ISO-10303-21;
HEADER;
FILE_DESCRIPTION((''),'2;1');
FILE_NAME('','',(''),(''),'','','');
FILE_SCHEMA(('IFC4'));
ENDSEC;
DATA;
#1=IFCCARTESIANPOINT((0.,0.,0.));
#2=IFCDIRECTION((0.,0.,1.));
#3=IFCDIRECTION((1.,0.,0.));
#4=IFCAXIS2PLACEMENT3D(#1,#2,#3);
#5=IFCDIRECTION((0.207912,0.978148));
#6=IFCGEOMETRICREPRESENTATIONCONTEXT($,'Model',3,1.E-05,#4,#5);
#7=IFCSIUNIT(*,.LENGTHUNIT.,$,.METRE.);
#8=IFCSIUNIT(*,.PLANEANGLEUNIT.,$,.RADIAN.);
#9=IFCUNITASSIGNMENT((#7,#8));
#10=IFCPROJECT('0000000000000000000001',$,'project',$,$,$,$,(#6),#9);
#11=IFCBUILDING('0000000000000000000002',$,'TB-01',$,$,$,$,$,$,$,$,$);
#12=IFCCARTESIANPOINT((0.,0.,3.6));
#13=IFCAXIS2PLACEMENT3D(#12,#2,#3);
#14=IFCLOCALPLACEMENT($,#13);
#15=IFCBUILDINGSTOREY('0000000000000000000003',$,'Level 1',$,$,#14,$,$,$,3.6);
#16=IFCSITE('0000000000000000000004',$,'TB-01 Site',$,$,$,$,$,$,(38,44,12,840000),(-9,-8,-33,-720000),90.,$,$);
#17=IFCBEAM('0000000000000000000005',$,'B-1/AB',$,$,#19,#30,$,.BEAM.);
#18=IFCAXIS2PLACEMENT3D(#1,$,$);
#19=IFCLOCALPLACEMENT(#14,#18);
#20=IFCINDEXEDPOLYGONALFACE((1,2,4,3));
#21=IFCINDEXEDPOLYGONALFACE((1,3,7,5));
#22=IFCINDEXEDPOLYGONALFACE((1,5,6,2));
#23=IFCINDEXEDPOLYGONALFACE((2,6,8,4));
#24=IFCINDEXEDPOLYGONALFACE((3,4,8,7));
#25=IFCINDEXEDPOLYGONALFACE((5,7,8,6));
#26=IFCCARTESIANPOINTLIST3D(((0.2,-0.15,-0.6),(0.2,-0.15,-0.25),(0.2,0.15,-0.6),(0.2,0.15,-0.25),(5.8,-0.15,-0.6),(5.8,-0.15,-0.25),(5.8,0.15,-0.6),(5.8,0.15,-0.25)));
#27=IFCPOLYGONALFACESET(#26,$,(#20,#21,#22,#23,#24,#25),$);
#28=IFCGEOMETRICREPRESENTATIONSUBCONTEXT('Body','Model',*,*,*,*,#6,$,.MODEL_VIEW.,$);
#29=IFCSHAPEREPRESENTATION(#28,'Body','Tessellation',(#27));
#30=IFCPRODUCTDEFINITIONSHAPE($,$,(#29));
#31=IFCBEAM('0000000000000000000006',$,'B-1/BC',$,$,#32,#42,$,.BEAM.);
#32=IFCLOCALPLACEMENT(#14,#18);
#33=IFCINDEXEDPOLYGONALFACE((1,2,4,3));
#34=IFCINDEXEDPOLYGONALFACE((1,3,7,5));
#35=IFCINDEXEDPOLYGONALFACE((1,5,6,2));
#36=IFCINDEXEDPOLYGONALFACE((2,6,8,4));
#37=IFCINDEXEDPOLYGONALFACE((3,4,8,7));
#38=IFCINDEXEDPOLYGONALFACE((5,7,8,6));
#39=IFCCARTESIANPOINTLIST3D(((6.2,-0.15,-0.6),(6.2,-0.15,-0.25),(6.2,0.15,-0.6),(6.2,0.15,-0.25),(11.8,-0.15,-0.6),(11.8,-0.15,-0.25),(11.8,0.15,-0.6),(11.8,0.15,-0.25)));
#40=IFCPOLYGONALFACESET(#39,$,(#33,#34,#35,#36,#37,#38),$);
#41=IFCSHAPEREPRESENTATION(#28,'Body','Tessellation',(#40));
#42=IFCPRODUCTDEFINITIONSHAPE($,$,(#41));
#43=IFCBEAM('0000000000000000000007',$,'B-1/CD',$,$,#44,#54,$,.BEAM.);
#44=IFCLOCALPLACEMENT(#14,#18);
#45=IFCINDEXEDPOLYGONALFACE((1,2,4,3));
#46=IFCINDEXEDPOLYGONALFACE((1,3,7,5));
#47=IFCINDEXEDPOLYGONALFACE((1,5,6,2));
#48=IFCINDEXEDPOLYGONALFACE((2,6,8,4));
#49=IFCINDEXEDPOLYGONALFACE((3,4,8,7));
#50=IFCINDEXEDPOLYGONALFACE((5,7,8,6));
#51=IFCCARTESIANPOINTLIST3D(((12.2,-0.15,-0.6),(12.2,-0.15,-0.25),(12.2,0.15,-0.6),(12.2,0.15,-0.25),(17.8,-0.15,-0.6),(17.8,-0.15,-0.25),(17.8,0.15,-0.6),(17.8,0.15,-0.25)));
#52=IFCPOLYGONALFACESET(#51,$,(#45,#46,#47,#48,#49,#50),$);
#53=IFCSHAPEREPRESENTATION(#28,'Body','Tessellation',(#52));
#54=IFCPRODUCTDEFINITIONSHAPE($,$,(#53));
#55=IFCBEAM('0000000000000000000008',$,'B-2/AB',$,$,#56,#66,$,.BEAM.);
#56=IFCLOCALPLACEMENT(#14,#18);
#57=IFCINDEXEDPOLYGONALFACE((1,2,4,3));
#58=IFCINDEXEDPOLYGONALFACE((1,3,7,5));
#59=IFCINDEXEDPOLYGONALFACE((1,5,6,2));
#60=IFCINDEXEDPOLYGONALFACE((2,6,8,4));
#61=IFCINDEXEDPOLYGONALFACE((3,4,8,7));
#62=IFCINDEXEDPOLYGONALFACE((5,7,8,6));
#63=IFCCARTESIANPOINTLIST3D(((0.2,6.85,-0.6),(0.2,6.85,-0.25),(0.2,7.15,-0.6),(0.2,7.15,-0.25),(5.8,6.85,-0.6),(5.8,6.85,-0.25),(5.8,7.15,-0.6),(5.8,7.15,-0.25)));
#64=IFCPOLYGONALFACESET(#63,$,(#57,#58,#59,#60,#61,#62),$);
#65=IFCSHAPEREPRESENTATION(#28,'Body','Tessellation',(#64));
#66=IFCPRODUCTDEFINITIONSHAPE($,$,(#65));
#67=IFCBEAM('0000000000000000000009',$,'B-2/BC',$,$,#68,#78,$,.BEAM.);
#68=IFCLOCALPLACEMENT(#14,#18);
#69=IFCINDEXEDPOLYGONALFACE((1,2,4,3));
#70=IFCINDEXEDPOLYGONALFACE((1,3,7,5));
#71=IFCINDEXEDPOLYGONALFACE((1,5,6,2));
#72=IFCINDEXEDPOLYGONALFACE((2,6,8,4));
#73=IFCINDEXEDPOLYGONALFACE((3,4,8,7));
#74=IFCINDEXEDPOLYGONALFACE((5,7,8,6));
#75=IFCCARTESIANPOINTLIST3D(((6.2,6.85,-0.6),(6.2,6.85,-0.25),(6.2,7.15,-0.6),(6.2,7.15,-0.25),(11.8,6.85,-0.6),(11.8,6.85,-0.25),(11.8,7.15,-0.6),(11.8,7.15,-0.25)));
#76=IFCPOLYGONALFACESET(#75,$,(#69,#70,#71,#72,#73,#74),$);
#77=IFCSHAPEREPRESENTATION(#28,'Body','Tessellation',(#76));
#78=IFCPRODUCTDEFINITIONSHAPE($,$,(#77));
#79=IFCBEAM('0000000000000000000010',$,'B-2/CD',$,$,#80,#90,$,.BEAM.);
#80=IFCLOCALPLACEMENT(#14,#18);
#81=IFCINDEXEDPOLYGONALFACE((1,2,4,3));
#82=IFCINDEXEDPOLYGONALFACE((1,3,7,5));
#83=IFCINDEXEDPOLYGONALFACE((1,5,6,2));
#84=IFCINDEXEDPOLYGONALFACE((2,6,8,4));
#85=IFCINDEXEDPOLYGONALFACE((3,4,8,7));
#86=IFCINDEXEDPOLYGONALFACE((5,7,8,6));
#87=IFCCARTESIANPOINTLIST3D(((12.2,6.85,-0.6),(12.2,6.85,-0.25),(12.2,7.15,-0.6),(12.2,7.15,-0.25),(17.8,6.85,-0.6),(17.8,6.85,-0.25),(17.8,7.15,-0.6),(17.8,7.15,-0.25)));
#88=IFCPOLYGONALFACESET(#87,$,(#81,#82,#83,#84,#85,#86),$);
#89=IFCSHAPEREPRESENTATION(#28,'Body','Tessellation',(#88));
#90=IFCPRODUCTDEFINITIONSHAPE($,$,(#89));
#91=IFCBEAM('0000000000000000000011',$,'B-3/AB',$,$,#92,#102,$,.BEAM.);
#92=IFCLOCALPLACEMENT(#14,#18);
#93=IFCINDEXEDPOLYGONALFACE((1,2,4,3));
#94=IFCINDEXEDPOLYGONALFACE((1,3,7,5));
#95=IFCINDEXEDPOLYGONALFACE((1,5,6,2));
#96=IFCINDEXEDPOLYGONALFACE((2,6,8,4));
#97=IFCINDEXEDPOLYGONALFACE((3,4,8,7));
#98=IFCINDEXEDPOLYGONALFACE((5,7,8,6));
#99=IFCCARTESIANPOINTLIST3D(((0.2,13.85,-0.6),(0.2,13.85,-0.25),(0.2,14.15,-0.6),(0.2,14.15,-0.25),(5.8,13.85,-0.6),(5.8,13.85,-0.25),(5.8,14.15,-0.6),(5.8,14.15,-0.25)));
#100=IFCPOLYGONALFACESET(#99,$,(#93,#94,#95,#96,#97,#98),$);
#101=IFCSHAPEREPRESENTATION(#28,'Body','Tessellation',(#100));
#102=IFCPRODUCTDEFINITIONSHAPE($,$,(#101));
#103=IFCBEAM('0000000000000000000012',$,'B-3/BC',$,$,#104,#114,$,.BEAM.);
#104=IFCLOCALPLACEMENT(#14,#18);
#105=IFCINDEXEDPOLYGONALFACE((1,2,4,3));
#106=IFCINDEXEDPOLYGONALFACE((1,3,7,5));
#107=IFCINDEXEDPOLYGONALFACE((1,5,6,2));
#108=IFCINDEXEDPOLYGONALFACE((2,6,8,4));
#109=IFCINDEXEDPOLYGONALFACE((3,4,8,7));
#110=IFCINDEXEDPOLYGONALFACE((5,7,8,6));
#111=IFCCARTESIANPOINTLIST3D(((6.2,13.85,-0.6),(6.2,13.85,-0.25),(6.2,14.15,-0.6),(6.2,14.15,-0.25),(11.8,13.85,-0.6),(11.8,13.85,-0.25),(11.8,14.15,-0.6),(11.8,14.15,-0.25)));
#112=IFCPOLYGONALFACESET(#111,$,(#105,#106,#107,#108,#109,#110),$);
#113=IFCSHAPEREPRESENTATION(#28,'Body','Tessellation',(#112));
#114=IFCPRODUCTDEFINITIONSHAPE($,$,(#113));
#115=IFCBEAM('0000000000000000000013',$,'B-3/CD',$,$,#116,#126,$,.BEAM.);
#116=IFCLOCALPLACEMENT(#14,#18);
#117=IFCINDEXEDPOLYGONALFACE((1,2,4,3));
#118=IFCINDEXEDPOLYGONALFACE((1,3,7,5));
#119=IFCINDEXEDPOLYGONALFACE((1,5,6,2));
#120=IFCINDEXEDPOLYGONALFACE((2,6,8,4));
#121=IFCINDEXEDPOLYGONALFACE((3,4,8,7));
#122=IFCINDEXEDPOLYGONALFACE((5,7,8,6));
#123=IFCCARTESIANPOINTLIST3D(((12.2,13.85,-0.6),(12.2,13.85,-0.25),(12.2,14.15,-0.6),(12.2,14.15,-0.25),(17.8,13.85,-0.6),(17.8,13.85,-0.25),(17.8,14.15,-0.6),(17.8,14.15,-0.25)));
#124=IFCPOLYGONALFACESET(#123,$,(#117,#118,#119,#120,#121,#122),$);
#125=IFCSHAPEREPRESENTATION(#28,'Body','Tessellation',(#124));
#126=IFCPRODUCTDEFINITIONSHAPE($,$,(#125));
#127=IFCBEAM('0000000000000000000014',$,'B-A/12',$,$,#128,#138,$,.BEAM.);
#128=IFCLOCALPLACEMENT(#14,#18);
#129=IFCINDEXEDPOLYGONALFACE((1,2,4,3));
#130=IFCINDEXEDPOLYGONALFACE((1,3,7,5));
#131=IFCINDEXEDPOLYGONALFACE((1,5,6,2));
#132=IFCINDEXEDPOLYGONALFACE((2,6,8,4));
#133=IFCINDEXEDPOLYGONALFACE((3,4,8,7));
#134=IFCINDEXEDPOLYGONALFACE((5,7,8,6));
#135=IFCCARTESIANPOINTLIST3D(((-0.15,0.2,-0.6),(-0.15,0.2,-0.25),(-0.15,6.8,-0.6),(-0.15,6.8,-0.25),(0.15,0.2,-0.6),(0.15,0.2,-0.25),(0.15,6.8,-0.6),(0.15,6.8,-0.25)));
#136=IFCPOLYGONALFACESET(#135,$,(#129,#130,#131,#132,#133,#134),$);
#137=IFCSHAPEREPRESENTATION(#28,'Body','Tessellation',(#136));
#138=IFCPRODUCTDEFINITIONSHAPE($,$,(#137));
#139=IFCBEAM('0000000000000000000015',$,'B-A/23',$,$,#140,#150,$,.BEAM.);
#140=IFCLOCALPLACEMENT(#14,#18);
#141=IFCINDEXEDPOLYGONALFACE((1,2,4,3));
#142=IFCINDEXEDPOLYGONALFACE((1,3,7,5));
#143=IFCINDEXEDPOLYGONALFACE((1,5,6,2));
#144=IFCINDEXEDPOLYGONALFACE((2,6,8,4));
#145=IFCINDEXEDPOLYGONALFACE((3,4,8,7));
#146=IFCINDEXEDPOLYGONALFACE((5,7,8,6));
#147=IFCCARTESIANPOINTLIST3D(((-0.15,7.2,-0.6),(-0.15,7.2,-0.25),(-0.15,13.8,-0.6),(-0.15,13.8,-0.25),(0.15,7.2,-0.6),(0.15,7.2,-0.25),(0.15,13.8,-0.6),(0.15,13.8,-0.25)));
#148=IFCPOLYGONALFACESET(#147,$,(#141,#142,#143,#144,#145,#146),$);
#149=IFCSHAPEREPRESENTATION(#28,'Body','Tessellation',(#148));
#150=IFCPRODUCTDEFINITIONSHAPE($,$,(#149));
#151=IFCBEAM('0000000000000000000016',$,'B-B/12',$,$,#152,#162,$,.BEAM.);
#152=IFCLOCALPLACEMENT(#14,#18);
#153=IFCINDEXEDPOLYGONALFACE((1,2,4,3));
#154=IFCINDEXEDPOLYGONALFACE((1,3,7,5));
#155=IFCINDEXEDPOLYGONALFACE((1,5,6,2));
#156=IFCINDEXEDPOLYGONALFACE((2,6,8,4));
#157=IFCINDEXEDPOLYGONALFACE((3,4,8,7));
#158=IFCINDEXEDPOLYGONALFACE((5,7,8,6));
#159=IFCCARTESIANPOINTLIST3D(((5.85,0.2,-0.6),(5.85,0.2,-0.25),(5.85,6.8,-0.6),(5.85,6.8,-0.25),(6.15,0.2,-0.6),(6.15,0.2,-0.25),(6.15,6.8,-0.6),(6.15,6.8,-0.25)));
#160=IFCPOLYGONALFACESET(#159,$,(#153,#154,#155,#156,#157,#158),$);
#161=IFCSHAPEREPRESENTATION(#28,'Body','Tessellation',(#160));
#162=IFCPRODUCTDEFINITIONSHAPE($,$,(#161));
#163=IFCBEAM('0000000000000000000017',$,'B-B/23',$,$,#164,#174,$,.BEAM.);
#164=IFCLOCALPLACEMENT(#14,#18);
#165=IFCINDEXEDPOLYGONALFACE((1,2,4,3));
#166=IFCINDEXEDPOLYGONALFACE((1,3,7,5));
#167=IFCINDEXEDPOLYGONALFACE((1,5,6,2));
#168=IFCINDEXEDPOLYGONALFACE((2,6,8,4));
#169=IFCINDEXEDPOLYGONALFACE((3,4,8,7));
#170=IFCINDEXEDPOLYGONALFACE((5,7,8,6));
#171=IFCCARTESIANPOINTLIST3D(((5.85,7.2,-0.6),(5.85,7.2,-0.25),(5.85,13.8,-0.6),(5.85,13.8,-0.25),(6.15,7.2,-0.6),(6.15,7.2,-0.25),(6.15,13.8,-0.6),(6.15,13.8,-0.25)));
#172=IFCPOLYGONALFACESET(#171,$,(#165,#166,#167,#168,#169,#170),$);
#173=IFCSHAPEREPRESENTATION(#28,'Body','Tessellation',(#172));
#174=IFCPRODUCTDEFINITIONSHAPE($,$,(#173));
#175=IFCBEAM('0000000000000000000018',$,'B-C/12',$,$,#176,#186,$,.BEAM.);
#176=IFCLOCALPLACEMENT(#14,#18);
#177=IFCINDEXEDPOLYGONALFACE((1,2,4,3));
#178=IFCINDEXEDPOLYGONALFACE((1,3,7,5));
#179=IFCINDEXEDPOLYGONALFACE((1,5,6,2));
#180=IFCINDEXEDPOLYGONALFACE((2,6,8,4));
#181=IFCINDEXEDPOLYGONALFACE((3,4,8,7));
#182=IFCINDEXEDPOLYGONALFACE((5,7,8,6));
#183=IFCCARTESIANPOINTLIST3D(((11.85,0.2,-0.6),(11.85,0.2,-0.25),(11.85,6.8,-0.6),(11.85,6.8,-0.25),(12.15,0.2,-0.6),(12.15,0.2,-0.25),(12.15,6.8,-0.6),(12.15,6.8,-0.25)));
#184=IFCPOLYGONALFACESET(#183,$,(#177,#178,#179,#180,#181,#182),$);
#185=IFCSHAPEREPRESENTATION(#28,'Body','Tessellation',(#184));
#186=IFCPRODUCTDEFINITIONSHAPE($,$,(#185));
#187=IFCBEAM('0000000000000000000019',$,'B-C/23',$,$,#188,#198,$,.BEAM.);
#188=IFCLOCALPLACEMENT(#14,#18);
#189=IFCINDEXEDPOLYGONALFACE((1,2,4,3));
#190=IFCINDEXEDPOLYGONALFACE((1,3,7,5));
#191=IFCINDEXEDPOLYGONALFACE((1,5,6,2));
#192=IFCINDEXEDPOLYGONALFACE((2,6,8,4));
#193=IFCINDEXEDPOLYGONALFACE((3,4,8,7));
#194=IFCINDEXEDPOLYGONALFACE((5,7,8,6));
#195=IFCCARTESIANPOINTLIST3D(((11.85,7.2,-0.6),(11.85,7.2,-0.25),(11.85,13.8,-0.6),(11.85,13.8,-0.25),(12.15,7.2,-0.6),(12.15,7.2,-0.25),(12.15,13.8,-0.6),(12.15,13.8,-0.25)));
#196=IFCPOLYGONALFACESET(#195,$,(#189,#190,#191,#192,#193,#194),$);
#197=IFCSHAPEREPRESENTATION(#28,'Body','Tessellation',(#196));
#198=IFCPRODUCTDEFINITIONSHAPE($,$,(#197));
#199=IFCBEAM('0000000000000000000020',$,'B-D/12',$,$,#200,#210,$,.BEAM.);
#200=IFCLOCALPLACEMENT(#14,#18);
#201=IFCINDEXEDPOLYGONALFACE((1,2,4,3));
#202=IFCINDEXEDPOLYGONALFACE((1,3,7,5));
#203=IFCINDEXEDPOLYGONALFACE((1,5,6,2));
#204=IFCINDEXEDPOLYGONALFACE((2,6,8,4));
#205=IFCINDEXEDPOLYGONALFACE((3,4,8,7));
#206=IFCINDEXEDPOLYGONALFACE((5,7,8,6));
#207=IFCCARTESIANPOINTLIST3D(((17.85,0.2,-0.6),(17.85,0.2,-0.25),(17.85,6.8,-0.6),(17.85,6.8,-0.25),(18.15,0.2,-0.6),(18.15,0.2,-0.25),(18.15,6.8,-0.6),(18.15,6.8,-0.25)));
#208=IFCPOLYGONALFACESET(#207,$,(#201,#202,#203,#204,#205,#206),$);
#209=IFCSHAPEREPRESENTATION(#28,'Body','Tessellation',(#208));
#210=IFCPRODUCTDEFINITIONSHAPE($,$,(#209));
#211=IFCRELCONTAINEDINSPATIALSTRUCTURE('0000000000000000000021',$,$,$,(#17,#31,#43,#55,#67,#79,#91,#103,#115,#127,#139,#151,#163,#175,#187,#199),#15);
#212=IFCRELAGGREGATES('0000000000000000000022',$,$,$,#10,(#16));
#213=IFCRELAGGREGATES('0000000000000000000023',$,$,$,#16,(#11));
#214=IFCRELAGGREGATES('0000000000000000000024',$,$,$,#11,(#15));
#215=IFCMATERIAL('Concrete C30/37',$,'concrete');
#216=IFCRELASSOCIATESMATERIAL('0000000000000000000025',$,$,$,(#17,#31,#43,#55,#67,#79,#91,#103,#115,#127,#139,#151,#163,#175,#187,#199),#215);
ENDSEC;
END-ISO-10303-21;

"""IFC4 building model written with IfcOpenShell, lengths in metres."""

from ifc_helpers import new_model, si_unit, direction, frame, origin_with_axes, place, context, subcontext, project, spatial, rectangle, extrude, material, element, save


model = new_model("IFC4")

# Units and contexts
model_context = context("Model", 3, precision=1e-05, world=origin_with_axes(), true_north=direction((0.207912, 0.978148)))
body_context = subcontext(model_context, "Body", "Model", "MODEL_VIEW")
ifc_project = project(units=[si_unit("LENGTHUNIT", "METRE"), si_unit("PLANEANGLEUNIT", "RADIAN")], contexts=[model_context])

# Site, building, storey
site = spatial("IfcSite", under=ifc_project, Name="TB-01 Site", RefLatitude=(38, 44, 12, 840000), RefLongitude=(-9, -8, -33, -720000), RefElevation=90.0)
building = spatial("IfcBuilding", under=site, Name="TB-01")
storey_placement = place(None, frame((0.0, 0.0, 3.6), z_axis=(0.0, 0.0, 1.0), x_axis=(1.0, 0.0, 0.0)))
storey = spatial("IfcBuildingStorey", under=building, at=storey_placement, Name="Level 1", Elevation=3.6)

# Beams
ifc_material = material(Name="Concrete C30/37", Category="concrete")
beam_1_placement = place(storey_placement, frame((0.2, 0.0, -0.425), z_axis=(1.0, 0.0, 0.0), x_axis=(0.0, 1.0, 0.0)))
element("IfcBeam", 1, at=beam_1_placement, inside=storey, material=ifc_material, Name="B-1/AB", PredefinedType="BEAM", context=body_context, shape_type="SweptSolid", body=[
    extrude(rectangle(XDim=0.3, YDim=0.35), origin_with_axes(), (0.0, 0.0, 1.0), 5.6),
])
beam_2_placement = place(storey_placement, frame((6.2, 0.0, -0.425), z_axis=(1.0, 0.0, 0.0), x_axis=(0.0, 1.0, 0.0)))
element("IfcBeam", 2, at=beam_2_placement, inside=storey, material=ifc_material, Name="B-1/BC", PredefinedType="BEAM", context=body_context, shape_type="SweptSolid", body=[
    extrude(rectangle(XDim=0.3, YDim=0.35), origin_with_axes(), (0.0, 0.0, 1.0), 5.6),
])
beam_3_placement = place(storey_placement, frame((12.2, 0.0, -0.425), z_axis=(1.0, 0.0, 0.0), x_axis=(0.0, 1.0, 0.0)))
element("IfcBeam", 3, at=beam_3_placement, inside=storey, material=ifc_material, Name="B-1/CD", PredefinedType="BEAM", context=body_context, shape_type="SweptSolid", body=[
    extrude(rectangle(XDim=0.3, YDim=0.35), origin_with_axes(), (0.0, 0.0, 1.0), 5.6),
])
beam_4_placement = place(storey_placement, frame((0.2, 7.0, -0.425), z_axis=(1.0, 0.0, 0.0), x_axis=(0.0, 1.0, 0.0)))
element("IfcBeam", 4, at=beam_4_placement, inside=storey, material=ifc_material, Name="B-2/AB", PredefinedType="BEAM", context=body_context, shape_type="SweptSolid", body=[
    extrude(rectangle(XDim=0.3, YDim=0.35), origin_with_axes(), (0.0, 0.0, 1.0), 5.6),
])
beam_5_placement = place(storey_placement, frame((6.2, 7.0, -0.425), z_axis=(1.0, 0.0, 0.0), x_axis=(0.0, 1.0, 0.0)))
element("IfcBeam", 5, at=beam_5_placement, inside=storey, material=ifc_material, Name="B-2/BC", PredefinedType="BEAM", context=body_context, shape_type="SweptSolid", body=[
    extrude(rectangle(XDim=0.3, YDim=0.35), origin_with_axes(), (0.0, 0.0, 1.0), 5.6),
])
beam_6_placement = place(storey_placement, frame((12.2, 7.0, -0.425), z_axis=(1.0, 0.0, 0.0), x_axis=(0.0, 1.0, 0.0)))
element("IfcBeam", 6, at=beam_6_placement, inside=storey, material=ifc_material, Name="B-2/CD", PredefinedType="BEAM", context=body_context, shape_type="SweptSolid", body=[
    extrude(rectangle(XDim=0.3, YDim=0.35), origin_with_axes(), (0.0, 0.0, 1.0), 5.6),
])
beam_7_placement = place(storey_placement, frame((0.2, 14.0, -0.425), z_axis=(1.0, 0.0, 0.0), x_axis=(0.0, 1.0, 0.0)))
element("IfcBeam", 7, at=beam_7_placement, inside=storey, material=ifc_material, Name="B-3/AB", PredefinedType="BEAM", context=body_context, shape_type="SweptSolid", body=[
    extrude(rectangle(XDim=0.3, YDim=0.35), origin_with_axes(), (0.0, 0.0, 1.0), 5.6),
])
beam_8_placement = place(storey_placement, frame((6.2, 14.0, -0.425), z_axis=(1.0, 0.0, 0.0), x_axis=(0.0, 1.0, 0.0)))
element("IfcBeam", 8, at=beam_8_placement, inside=storey, material=ifc_material, Name="B-3/BC", PredefinedType="BEAM", context=body_context, shape_type="SweptSolid", body=[
    extrude(rectangle(XDim=0.3, YDim=0.35), origin_with_axes(), (0.0, 0.0, 1.0), 5.6),
])
beam_9_placement = place(storey_placement, frame((12.2, 14.0, -0.425), z_axis=(1.0, 0.0, 0.0), x_axis=(0.0, 1.0, 0.0)))
element("IfcBeam", 9, at=beam_9_placement, inside=storey, material=ifc_material, Name="B-3/CD", PredefinedType="BEAM", context=body_context, shape_type="SweptSolid", body=[
    extrude(rectangle(XDim=0.3, YDim=0.35), origin_with_axes(), (0.0, 0.0, 1.0), 5.6),
])
beam_10_placement = place(storey_placement, frame((0.0, 0.2, -0.425), z_axis=(0.0, 1.0, 0.0), x_axis=(-1.0, 0.0, 0.0)))
element("IfcBeam", 10, at=beam_10_placement, inside=storey, material=ifc_material, Name="B-A/12", PredefinedType="BEAM", context=body_context, shape_type="SweptSolid", body=[
    extrude(rectangle(XDim=0.3, YDim=0.35), origin_with_axes(), (0.0, 0.0, 1.0), 6.6),
])
beam_11_placement = place(storey_placement, frame((0.0, 7.2, -0.425), z_axis=(0.0, 1.0, 0.0), x_axis=(-1.0, 0.0, 0.0)))
element("IfcBeam", 11, at=beam_11_placement, inside=storey, material=ifc_material, Name="B-A/23", PredefinedType="BEAM", context=body_context, shape_type="SweptSolid", body=[
    extrude(rectangle(XDim=0.3, YDim=0.35), origin_with_axes(), (0.0, 0.0, 1.0), 6.6),
])
beam_12_placement = place(storey_placement, frame((6.0, 0.2, -0.425), z_axis=(0.0, 1.0, 0.0), x_axis=(-1.0, 0.0, 0.0)))
element("IfcBeam", 12, at=beam_12_placement, inside=storey, material=ifc_material, Name="B-B/12", PredefinedType="BEAM", context=body_context, shape_type="SweptSolid", body=[
    extrude(rectangle(XDim=0.3, YDim=0.35), origin_with_axes(), (0.0, 0.0, 1.0), 6.6),
])
beam_13_placement = place(storey_placement, frame((6.0, 7.2, -0.425), z_axis=(0.0, 1.0, 0.0), x_axis=(-1.0, 0.0, 0.0)))
element("IfcBeam", 13, at=beam_13_placement, inside=storey, material=ifc_material, Name="B-B/23", PredefinedType="BEAM", context=body_context, shape_type="SweptSolid", body=[
    extrude(rectangle(XDim=0.3, YDim=0.35), origin_with_axes(), (0.0, 0.0, 1.0), 6.6),
])
beam_14_placement = place(storey_placement, frame((12.0, 0.2, -0.425), z_axis=(0.0, 1.0, 0.0), x_axis=(-1.0, 0.0, 0.0)))
element("IfcBeam", 14, at=beam_14_placement, inside=storey, material=ifc_material, Name="B-C/12", PredefinedType="BEAM", context=body_context, shape_type="SweptSolid", body=[
    extrude(rectangle(XDim=0.3, YDim=0.35), origin_with_axes(), (0.0, 0.0, 1.0), 6.6),
])
beam_15_placement = place(storey_placement, frame((12.0, 7.2, -0.425), z_axis=(0.0, 1.0, 0.0), x_axis=(-1.0, 0.0, 0.0)))
element("IfcBeam", 15, at=beam_15_placement, inside=storey, material=ifc_material, Name="B-C/23", PredefinedType="BEAM", context=body_context, shape_type="SweptSolid", body=[
    extrude(rectangle(XDim=0.3, YDim=0.35), origin_with_axes(), (0.0, 0.0, 1.0), 6.6),
])
beam_16_placement = place(storey_placement, frame((18.0, 0.2, -0.425), z_axis=(0.0, 1.0, 0.0), x_axis=(-1.0, 0.0, 0.0)))
element("IfcBeam", 16, at=beam_16_placement, inside=storey, material=ifc_material, Name="B-D/12", PredefinedType="BEAM", context=body_context, shape_type="SweptSolid", body=[
    extrude(rectangle(XDim=0.3, YDim=0.35), origin_with_axes(), (0.0, 0.0, 1.0), 6.6),
])

save(model, "model.ifc")
